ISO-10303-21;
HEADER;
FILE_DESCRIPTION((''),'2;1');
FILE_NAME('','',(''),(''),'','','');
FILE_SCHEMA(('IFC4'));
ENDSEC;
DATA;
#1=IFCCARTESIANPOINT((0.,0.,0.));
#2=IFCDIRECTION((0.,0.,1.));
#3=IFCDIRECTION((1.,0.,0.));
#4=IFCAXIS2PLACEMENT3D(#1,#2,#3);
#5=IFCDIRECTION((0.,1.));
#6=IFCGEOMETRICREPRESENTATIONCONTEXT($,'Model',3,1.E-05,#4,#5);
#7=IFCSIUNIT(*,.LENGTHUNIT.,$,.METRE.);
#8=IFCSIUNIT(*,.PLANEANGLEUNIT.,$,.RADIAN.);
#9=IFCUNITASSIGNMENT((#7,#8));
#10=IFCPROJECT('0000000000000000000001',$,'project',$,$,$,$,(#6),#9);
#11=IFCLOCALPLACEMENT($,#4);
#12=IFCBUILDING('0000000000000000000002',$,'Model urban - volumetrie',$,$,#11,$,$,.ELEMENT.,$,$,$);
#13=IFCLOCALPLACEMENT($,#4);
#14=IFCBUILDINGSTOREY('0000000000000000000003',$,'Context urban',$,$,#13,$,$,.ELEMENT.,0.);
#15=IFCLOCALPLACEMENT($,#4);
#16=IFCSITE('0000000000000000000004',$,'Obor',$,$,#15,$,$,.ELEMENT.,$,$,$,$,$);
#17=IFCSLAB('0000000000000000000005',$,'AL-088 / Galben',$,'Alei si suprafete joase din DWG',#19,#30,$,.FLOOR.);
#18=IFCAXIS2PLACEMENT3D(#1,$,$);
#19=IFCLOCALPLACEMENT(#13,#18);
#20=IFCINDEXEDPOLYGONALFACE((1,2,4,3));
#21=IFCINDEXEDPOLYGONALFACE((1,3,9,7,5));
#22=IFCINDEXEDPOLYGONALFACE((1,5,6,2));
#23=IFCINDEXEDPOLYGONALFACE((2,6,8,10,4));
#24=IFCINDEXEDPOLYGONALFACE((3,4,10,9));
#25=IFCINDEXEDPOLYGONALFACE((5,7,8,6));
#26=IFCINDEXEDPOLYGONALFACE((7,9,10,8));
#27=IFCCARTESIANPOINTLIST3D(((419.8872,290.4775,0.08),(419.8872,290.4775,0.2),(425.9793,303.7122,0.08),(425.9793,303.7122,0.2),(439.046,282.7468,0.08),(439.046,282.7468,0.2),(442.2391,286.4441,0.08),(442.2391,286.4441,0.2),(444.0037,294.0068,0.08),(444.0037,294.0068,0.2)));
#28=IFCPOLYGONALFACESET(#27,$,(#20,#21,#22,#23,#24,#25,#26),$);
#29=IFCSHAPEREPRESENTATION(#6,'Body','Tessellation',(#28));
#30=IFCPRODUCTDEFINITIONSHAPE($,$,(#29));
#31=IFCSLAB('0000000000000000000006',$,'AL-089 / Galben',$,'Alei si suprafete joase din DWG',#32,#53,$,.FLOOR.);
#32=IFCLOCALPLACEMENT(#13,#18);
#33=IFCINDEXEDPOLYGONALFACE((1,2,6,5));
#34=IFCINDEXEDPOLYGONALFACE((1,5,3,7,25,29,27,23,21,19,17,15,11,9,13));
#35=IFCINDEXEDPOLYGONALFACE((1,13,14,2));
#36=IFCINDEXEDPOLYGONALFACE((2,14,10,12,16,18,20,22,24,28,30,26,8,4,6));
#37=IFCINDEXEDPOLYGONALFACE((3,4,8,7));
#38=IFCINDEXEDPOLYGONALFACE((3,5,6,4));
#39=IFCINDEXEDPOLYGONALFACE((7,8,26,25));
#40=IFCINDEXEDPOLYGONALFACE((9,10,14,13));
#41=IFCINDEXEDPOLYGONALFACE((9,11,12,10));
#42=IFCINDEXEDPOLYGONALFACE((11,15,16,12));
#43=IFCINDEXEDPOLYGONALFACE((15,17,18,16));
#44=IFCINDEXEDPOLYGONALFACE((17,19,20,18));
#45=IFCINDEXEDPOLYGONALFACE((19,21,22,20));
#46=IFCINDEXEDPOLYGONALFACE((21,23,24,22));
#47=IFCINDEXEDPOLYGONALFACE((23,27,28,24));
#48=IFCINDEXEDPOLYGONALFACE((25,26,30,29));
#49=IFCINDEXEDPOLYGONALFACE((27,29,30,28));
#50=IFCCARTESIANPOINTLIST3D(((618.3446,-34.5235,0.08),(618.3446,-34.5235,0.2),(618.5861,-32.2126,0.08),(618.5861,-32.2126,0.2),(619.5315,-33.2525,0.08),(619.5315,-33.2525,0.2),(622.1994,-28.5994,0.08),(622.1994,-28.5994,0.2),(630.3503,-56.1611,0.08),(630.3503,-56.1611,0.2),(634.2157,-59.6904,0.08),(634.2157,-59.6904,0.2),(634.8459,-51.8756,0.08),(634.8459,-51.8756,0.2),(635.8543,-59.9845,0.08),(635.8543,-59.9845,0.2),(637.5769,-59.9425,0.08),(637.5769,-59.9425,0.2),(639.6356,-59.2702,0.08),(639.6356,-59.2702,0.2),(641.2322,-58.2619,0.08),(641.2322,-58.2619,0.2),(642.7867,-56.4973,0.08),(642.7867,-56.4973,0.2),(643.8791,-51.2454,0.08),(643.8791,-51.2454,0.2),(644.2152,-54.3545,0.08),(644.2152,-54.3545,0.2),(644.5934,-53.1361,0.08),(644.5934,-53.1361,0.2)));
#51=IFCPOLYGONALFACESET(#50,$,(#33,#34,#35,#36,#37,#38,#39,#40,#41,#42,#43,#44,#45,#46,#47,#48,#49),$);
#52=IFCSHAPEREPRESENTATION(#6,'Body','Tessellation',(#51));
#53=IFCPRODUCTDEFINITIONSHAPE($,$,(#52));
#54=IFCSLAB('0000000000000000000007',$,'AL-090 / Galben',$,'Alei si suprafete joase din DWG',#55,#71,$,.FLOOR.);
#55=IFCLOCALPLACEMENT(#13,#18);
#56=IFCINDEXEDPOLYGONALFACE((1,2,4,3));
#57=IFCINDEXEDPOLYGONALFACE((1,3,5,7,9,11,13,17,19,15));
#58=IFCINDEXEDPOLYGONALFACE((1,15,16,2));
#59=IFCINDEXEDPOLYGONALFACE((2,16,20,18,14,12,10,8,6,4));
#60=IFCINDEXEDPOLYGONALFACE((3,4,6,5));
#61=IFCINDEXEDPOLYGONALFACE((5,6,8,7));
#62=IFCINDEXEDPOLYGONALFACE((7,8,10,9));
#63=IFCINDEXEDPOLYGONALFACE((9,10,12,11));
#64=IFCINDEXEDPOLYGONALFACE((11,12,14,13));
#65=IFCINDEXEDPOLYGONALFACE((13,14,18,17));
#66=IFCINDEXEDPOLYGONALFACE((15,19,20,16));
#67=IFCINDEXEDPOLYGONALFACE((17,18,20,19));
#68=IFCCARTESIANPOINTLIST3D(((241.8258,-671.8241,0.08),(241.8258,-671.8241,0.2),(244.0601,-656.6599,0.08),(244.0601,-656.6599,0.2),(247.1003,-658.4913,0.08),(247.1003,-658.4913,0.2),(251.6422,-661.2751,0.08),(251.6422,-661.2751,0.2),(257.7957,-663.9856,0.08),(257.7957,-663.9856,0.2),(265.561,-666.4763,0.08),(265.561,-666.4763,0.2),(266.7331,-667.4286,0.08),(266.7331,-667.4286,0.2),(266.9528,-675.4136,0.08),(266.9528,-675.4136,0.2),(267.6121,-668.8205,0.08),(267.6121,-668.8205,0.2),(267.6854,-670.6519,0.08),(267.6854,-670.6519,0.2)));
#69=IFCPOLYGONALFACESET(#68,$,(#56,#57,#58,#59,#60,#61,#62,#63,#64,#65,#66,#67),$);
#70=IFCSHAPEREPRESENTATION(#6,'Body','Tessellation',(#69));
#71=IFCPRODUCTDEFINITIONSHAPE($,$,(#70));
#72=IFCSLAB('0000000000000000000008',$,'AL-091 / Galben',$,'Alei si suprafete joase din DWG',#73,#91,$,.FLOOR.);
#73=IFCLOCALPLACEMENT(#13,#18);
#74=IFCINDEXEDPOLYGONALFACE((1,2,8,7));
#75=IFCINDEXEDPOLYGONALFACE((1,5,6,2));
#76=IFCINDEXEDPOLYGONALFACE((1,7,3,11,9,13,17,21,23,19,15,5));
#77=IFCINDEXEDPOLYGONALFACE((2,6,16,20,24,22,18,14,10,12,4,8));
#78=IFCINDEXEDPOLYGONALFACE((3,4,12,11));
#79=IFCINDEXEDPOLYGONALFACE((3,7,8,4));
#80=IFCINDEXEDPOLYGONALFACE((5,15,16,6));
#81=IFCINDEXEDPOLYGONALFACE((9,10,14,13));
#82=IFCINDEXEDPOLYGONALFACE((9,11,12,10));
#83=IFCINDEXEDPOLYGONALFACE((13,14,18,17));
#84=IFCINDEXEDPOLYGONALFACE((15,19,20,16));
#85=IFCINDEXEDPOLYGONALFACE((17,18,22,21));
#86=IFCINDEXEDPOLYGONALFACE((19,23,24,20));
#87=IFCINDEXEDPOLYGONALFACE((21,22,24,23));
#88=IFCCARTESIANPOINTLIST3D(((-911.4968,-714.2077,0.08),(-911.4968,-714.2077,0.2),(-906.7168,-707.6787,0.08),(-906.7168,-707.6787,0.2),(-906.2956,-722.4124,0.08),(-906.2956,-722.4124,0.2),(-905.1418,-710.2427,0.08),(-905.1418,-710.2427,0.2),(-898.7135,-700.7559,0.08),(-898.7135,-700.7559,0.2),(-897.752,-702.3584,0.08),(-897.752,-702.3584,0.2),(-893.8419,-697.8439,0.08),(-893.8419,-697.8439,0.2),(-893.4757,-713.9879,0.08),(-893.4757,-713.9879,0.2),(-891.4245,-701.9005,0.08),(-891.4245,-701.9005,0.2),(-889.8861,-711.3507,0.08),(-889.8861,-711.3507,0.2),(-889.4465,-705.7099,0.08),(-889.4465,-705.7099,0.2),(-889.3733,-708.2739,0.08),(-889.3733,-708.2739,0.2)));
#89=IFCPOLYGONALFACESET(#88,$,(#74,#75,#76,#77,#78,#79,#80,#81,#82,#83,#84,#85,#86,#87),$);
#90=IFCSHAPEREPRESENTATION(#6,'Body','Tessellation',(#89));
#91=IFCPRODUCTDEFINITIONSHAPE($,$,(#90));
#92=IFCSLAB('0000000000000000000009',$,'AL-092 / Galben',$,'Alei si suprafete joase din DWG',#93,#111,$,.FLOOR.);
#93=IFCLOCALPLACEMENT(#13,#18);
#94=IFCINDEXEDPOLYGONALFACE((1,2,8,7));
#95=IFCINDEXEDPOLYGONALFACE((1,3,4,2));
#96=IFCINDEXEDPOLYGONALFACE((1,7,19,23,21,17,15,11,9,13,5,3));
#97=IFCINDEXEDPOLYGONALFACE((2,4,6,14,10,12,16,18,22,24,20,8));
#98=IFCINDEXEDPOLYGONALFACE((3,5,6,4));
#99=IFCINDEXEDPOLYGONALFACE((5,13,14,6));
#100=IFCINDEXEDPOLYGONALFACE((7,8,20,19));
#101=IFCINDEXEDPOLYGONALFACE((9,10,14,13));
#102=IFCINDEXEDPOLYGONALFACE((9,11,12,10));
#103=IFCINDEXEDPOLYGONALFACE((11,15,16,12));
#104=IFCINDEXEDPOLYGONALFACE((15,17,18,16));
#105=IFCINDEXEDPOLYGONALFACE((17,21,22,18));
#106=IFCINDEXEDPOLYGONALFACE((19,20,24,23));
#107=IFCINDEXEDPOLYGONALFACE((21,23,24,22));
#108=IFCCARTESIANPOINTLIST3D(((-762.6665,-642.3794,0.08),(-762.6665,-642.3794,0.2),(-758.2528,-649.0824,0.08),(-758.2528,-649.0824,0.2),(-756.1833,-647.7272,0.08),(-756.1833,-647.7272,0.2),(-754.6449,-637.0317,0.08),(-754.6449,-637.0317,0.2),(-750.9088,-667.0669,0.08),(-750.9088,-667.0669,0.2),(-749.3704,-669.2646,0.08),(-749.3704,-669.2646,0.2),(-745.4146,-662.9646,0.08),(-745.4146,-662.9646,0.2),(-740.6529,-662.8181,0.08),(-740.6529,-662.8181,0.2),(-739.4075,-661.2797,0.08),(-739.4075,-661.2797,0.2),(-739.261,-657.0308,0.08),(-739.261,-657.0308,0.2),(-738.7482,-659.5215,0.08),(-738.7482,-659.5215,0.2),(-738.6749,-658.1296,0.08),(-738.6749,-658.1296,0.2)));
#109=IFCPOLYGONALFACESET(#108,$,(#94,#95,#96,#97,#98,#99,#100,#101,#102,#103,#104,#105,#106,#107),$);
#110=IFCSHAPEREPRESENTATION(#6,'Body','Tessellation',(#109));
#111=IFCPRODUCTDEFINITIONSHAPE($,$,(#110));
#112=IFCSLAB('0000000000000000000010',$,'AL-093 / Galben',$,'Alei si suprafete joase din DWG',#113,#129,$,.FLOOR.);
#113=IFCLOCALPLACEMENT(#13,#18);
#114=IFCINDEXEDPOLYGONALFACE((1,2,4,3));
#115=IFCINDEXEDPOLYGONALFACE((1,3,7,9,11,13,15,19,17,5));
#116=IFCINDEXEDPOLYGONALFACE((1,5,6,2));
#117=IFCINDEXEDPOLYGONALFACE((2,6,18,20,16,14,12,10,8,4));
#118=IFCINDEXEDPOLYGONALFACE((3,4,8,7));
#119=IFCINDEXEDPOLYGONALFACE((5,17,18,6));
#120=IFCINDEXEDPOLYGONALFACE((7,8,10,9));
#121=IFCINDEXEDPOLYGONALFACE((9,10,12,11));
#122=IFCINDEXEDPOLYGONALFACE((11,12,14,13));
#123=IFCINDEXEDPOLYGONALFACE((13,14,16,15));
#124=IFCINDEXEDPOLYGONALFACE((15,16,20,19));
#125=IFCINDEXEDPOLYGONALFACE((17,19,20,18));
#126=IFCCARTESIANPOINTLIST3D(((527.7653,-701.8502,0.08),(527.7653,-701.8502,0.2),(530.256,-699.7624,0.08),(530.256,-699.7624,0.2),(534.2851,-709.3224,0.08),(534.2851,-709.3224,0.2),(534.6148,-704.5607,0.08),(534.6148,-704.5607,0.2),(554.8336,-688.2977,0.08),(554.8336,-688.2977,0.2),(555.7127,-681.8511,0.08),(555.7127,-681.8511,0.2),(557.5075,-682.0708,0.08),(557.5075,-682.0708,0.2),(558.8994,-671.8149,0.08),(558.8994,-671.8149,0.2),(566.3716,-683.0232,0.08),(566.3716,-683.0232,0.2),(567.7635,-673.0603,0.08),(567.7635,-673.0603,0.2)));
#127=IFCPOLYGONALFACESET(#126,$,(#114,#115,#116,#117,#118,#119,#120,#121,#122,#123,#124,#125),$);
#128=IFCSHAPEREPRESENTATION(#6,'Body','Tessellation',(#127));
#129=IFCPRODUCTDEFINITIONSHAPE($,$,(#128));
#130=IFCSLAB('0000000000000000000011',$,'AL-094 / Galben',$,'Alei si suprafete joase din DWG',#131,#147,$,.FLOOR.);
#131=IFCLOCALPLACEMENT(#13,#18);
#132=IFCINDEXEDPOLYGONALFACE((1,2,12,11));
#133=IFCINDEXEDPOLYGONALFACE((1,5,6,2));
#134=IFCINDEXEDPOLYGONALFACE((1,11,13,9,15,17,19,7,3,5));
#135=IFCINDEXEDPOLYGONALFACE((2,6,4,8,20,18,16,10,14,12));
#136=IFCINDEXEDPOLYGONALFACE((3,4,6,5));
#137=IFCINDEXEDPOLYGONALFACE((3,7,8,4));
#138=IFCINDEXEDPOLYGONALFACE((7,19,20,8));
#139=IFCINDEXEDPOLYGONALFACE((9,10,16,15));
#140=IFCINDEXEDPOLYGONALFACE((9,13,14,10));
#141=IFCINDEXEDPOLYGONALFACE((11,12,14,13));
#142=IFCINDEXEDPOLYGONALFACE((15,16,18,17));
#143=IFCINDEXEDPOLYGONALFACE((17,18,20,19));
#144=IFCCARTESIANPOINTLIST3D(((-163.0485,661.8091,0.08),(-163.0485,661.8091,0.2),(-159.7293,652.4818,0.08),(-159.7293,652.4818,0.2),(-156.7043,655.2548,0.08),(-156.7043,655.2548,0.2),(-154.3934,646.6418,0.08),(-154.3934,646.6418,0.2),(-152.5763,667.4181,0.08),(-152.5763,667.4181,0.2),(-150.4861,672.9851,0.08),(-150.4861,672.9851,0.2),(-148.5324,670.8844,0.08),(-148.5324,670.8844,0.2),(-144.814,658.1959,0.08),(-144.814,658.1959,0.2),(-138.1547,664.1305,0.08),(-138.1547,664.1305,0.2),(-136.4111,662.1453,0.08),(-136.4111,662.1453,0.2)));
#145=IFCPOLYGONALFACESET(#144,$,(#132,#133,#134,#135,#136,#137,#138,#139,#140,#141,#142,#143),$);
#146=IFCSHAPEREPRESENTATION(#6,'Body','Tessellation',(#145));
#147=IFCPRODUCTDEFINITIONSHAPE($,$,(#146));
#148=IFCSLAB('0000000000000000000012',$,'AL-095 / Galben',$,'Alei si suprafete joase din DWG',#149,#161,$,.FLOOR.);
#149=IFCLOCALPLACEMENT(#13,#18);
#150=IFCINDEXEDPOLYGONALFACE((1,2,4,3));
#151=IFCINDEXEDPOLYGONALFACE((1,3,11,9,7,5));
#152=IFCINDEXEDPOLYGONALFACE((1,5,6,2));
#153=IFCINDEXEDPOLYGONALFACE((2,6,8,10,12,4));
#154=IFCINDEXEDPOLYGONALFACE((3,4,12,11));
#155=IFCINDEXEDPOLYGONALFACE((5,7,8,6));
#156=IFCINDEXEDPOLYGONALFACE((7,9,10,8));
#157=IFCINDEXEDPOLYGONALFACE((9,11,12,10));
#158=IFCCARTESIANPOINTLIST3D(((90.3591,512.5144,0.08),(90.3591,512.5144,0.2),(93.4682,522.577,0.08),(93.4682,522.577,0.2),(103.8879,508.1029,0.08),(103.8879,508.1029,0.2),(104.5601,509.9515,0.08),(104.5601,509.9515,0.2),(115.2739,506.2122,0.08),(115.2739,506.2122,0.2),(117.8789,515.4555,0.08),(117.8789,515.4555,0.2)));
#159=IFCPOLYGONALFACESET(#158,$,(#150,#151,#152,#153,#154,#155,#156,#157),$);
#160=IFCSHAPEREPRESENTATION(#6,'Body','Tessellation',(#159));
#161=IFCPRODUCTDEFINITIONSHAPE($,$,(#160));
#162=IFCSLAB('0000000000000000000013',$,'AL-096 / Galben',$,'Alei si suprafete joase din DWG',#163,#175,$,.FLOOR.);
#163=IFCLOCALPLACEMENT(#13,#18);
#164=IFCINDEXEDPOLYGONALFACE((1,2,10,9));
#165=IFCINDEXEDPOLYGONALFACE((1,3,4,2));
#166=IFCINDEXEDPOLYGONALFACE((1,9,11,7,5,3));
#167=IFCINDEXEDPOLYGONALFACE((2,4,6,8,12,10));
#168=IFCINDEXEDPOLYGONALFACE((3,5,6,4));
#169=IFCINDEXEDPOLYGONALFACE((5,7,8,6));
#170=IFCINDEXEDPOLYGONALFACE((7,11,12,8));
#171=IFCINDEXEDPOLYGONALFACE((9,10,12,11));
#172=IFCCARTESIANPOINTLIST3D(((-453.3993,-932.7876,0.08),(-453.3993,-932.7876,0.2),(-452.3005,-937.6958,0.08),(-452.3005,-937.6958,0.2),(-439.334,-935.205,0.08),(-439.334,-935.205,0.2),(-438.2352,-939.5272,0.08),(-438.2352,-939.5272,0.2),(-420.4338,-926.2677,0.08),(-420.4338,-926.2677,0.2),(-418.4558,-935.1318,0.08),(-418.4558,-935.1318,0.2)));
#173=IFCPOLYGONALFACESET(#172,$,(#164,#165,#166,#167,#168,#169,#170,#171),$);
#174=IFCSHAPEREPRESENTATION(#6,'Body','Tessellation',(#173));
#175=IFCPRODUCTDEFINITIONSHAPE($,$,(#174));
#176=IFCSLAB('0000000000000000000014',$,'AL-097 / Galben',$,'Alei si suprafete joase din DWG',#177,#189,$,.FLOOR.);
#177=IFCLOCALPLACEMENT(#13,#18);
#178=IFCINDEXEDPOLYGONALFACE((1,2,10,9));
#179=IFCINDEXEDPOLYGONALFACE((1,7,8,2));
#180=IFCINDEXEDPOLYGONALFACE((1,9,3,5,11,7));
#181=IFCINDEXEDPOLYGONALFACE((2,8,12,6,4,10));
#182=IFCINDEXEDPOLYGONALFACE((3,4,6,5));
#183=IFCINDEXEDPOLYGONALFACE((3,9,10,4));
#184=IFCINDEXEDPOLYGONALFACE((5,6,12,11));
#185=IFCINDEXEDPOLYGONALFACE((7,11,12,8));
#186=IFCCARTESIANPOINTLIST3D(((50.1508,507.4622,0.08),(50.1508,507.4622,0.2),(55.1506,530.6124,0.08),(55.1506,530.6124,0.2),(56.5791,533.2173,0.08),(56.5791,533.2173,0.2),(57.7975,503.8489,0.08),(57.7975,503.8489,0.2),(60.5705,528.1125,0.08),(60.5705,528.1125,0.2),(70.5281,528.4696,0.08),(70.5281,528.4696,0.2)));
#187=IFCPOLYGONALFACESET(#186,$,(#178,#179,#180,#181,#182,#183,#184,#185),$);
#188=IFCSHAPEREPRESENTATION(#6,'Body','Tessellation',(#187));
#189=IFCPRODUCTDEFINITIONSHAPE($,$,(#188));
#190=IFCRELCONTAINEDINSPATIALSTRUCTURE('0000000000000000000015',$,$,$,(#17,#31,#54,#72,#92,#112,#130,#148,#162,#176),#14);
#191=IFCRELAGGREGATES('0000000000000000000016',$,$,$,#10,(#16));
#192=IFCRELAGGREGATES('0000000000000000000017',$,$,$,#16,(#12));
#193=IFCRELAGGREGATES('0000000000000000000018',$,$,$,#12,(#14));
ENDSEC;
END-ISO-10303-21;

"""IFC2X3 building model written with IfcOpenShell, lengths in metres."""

from ifc_helpers import new_model, si_unit, direction, frame, origin_with_axes, place, context, project, spatial, polyline, outline, extrude, element, save


model = new_model("IFC2X3")

# Units and contexts
model_context = context("Model", 3, precision=1e-05, world=origin_with_axes(), true_north=direction((0.0, 1.0)))
ifc_project = project(units=[si_unit("LENGTHUNIT", "METRE"), si_unit("PLANEANGLEUNIT", "RADIAN")], contexts=[model_context])

# Site, building, storey
site_placement = place(None, origin_with_axes())
site = spatial("IfcSite", under=ifc_project, at=site_placement, Name="Obor", CompositionType="ELEMENT")
building_placement = place(None, origin_with_axes())
building = spatial("IfcBuilding", under=site, at=building_placement, Name="Model urban - volumetrie", CompositionType="ELEMENT")
storey_placement = place(None, origin_with_axes())
storey = spatial("IfcBuildingStorey", under=building, at=storey_placement, Name="Context urban", CompositionType="ELEMENT", Elevation=0.0)

# Slabs
slab_1_placement = place(None, origin_with_axes())
element("IfcSlab", 1, at=slab_1_placement, inside=storey, Name="AL-088 / Galben", ObjectType="Alei si suprafete joase din DWG", PredefinedType="FLOOR", context=model_context, shape_type="SweptSolid", body=[
    extrude(outline(polyline([(425.9793, 303.7122), (419.8872, 290.4775), (439.046, 282.7468), (442.2391, 286.4441), (444.0037, 294.0068), (425.9793, 303.7122)])), frame((0.0, 0.0, 0.08), z_axis=(0.0, 0.0, 1.0), x_axis=(1.0, 0.0, 0.0)), (0.0, 0.0, 1.0), 0.12),
])
slab_2_placement = place(None, origin_with_axes())
element("IfcSlab", 2, at=slab_2_placement, inside=storey, Name="AL-089 / Galben", ObjectType="Alei si suprafete joase din DWG", PredefinedType="FLOOR", context=model_context, shape_type="SweptSolid", body=[
    extrude(outline(polyline([(642.7867, -56.4973), (644.2152, -54.3545), (644.5934, -53.1361), (643.8791, -51.2454), (622.1994, -28.5994), (618.5861, -32.2126), (619.5315, -33.2525), (618.3446, -34.5235), (634.8459, -51.8756), (630.3503, -56.1611), (634.2157, -59.6904), (635.8543, -59.9845), (637.5769, -59.9425), (639.6356, -59.2702), (641.2322, -58.2619), (642.7867, -56.4973)])), frame((0.0, 0.0, 0.08), z_axis=(0.0, 0.0, 1.0), x_axis=(1.0, 0.0, 0.0)), (0.0, 0.0, 1.0), 0.12),
])
slab_3_placement = place(None, origin_with_axes())
element("IfcSlab", 3, at=slab_3_placement, inside=storey, Name="AL-090 / Galben", ObjectType="Alei si suprafete joase din DWG", PredefinedType="FLOOR", context=model_context, shape_type="SweptSolid", body=[
    extrude(outline(polyline([(265.561, -666.4763), (257.7957, -663.9856), (251.6422, -661.2751), (247.1003, -658.4913), (244.0601, -656.6599), (241.8258, -671.8241), (266.9528, -675.4136), (267.6854, -670.6519), (267.6121, -668.8205), (266.7331, -667.4286), (265.561, -666.4763)])), frame((0.0, 0.0, 0.08), z_axis=(0.0, 0.0, 1.0), x_axis=(1.0, 0.0, 0.0)), (0.0, 0.0, 1.0), 0.12),
])
slab_4_placement = place(None, origin_with_axes())
element("IfcSlab", 4, at=slab_4_placement, inside=storey, Name="AL-091 / Galben", ObjectType="Alei si suprafete joase din DWG", PredefinedType="FLOOR", context=model_context, shape_type="SweptSolid", body=[
    extrude(outline(polyline([(-893.8419, -697.8439), (-898.7135, -700.7559), (-897.752, -702.3584), (-906.7168, -707.6787), (-905.1418, -710.2427), (-911.4968, -714.2077), (-906.2956, -722.4124), (-893.4757, -713.9879), (-889.8861, -711.3507), (-889.3733, -708.2739), (-889.4465, -705.7099), (-891.4245, -701.9005), (-893.8419, -697.8439)])), frame((0.0, 0.0, 0.08), z_axis=(0.0, 0.0, 1.0), x_axis=(1.0, 0.0, 0.0)), (0.0, 0.0, 1.0), 0.12),
])
slab_5_placement = place(None, origin_with_axes())
element("IfcSlab", 5, at=slab_5_placement, inside=storey, Name="AL-092 / Galben", ObjectType="Alei si suprafete joase din DWG", PredefinedType="FLOOR", context=model_context, shape_type="SweptSolid", body=[
    extrude(outline(polyline([(-739.4075, -661.2797), (-738.7482, -659.5215), (-738.6749, -658.1296), (-739.261, -657.0308), (-754.6449, -637.0317), (-762.6665, -642.3794), (-758.2528, -649.0824), (-756.1833, -647.7272), (-745.4146, -662.9646), (-750.9088, -667.0669), (-749.3704, -669.2646), (-740.6529, -662.8181), (-739.4075, -661.2797)])), frame((0.0, 0.0, 0.08), z_axis=(0.0, 0.0, 1.0), x_axis=(1.0, 0.0, 0.0)), (0.0, 0.0, 1.0), 0.12),
])
slab_6_placement = place(None, origin_with_axes())
element("IfcSlab", 6, at=slab_6_placement, inside=storey, Name="AL-093 / Galben", ObjectType="Alei si suprafete joase din DWG", PredefinedType="FLOOR", context=model_context, shape_type="SweptSolid", body=[
    extrude(outline(polyline([(558.8994, -671.8149), (557.5075, -682.0708), (555.7127, -681.8511), (554.8336, -688.2977), (534.6148, -704.5607), (530.256, -699.7624), (527.7653, -701.8502), (534.2851, -709.3224), (566.3716, -683.0232), (567.7635, -673.0603), (558.8994, -671.8149)])), frame((0.0, 0.0, 0.08), z_axis=(0.0, 0.0, 1.0), x_axis=(1.0, 0.0, 0.0)), (0.0, 0.0, 1.0), 0.12),
])
slab_7_placement = place(None, origin_with_axes())
element("IfcSlab", 7, at=slab_7_placement, inside=storey, Name="AL-094 / Galben", ObjectType="Alei si suprafete joase din DWG", PredefinedType="FLOOR", context=model_context, shape_type="SweptSolid", body=[
    extrude(outline(polyline([(-136.4111, 662.1453), (-138.1547, 664.1305), (-144.814, 658.1959), (-152.5763, 667.4181), (-148.5324, 670.8844), (-150.4861, 672.9851), (-163.0485, 661.8091), (-156.7043, 655.2548), (-159.7293, 652.4818), (-154.3934, 646.6418), (-136.4111, 662.1453)])), frame((0.0, 0.0, 0.08), z_axis=(0.0, 0.0, 1.0), x_axis=(1.0, 0.0, 0.0)), (0.0, 0.0, 1.0), 0.12),
])
slab_8_placement = place(None, origin_with_axes())
element("IfcSlab", 8, at=slab_8_placement, inside=storey, Name="AL-095 / Galben", ObjectType="Alei si suprafete joase din DWG", PredefinedType="FLOOR", context=model_context, shape_type="SweptSolid", body=[
    extrude(outline(polyline([(103.8879, 508.1029), (104.5601, 509.9515), (115.2739, 506.2122), (117.8789, 515.4555), (93.4682, 522.577), (90.3591, 512.5144), (103.8879, 508.1029)])), frame((0.0, 0.0, 0.08), z_axis=(0.0, 0.0, 1.0), x_axis=(1.0, 0.0, 0.0)), (0.0, 0.0, 1.0), 0.12),
])
slab_9_placement = place(None, origin_with_axes())
element("IfcSlab", 9, at=slab_9_placement, inside=storey, Name="AL-096 / Galben", ObjectType="Alei si suprafete joase din DWG", PredefinedType="FLOOR", context=model_context, shape_type="SweptSolid", body=[
    extrude(outline(polyline([(-452.3005, -937.6958), (-439.334, -935.205), (-438.2352, -939.5272), (-418.4558, -935.1318), (-420.4338, -926.2677), (-453.3993, -932.7876), (-452.3005, -937.6958)])), frame((0.0, 0.0, 0.08), z_axis=(0.0, 0.0, 1.0), x_axis=(1.0, 0.0, 0.0)), (0.0, 0.0, 1.0), 0.12),
])
slab_10_placement = place(None, origin_with_axes())
element("IfcSlab", 10, at=slab_10_placement, inside=storey, Name="AL-097 / Galben", ObjectType="Alei si suprafete joase din DWG", PredefinedType="FLOOR", context=model_context, shape_type="SweptSolid", body=[
    extrude(outline(polyline([(60.5705, 528.1125), (50.1508, 507.4622), (57.7975, 503.8489), (70.5281, 528.4696), (56.5791, 533.2173), (55.1506, 530.6124), (60.5705, 528.1125)])), frame((0.0, 0.0, 0.08), z_axis=(0.0, 0.0, 1.0), x_axis=(1.0, 0.0, 0.0)), (0.0, 0.0, 1.0), 0.12),
])

save(model, "model.ifc")
